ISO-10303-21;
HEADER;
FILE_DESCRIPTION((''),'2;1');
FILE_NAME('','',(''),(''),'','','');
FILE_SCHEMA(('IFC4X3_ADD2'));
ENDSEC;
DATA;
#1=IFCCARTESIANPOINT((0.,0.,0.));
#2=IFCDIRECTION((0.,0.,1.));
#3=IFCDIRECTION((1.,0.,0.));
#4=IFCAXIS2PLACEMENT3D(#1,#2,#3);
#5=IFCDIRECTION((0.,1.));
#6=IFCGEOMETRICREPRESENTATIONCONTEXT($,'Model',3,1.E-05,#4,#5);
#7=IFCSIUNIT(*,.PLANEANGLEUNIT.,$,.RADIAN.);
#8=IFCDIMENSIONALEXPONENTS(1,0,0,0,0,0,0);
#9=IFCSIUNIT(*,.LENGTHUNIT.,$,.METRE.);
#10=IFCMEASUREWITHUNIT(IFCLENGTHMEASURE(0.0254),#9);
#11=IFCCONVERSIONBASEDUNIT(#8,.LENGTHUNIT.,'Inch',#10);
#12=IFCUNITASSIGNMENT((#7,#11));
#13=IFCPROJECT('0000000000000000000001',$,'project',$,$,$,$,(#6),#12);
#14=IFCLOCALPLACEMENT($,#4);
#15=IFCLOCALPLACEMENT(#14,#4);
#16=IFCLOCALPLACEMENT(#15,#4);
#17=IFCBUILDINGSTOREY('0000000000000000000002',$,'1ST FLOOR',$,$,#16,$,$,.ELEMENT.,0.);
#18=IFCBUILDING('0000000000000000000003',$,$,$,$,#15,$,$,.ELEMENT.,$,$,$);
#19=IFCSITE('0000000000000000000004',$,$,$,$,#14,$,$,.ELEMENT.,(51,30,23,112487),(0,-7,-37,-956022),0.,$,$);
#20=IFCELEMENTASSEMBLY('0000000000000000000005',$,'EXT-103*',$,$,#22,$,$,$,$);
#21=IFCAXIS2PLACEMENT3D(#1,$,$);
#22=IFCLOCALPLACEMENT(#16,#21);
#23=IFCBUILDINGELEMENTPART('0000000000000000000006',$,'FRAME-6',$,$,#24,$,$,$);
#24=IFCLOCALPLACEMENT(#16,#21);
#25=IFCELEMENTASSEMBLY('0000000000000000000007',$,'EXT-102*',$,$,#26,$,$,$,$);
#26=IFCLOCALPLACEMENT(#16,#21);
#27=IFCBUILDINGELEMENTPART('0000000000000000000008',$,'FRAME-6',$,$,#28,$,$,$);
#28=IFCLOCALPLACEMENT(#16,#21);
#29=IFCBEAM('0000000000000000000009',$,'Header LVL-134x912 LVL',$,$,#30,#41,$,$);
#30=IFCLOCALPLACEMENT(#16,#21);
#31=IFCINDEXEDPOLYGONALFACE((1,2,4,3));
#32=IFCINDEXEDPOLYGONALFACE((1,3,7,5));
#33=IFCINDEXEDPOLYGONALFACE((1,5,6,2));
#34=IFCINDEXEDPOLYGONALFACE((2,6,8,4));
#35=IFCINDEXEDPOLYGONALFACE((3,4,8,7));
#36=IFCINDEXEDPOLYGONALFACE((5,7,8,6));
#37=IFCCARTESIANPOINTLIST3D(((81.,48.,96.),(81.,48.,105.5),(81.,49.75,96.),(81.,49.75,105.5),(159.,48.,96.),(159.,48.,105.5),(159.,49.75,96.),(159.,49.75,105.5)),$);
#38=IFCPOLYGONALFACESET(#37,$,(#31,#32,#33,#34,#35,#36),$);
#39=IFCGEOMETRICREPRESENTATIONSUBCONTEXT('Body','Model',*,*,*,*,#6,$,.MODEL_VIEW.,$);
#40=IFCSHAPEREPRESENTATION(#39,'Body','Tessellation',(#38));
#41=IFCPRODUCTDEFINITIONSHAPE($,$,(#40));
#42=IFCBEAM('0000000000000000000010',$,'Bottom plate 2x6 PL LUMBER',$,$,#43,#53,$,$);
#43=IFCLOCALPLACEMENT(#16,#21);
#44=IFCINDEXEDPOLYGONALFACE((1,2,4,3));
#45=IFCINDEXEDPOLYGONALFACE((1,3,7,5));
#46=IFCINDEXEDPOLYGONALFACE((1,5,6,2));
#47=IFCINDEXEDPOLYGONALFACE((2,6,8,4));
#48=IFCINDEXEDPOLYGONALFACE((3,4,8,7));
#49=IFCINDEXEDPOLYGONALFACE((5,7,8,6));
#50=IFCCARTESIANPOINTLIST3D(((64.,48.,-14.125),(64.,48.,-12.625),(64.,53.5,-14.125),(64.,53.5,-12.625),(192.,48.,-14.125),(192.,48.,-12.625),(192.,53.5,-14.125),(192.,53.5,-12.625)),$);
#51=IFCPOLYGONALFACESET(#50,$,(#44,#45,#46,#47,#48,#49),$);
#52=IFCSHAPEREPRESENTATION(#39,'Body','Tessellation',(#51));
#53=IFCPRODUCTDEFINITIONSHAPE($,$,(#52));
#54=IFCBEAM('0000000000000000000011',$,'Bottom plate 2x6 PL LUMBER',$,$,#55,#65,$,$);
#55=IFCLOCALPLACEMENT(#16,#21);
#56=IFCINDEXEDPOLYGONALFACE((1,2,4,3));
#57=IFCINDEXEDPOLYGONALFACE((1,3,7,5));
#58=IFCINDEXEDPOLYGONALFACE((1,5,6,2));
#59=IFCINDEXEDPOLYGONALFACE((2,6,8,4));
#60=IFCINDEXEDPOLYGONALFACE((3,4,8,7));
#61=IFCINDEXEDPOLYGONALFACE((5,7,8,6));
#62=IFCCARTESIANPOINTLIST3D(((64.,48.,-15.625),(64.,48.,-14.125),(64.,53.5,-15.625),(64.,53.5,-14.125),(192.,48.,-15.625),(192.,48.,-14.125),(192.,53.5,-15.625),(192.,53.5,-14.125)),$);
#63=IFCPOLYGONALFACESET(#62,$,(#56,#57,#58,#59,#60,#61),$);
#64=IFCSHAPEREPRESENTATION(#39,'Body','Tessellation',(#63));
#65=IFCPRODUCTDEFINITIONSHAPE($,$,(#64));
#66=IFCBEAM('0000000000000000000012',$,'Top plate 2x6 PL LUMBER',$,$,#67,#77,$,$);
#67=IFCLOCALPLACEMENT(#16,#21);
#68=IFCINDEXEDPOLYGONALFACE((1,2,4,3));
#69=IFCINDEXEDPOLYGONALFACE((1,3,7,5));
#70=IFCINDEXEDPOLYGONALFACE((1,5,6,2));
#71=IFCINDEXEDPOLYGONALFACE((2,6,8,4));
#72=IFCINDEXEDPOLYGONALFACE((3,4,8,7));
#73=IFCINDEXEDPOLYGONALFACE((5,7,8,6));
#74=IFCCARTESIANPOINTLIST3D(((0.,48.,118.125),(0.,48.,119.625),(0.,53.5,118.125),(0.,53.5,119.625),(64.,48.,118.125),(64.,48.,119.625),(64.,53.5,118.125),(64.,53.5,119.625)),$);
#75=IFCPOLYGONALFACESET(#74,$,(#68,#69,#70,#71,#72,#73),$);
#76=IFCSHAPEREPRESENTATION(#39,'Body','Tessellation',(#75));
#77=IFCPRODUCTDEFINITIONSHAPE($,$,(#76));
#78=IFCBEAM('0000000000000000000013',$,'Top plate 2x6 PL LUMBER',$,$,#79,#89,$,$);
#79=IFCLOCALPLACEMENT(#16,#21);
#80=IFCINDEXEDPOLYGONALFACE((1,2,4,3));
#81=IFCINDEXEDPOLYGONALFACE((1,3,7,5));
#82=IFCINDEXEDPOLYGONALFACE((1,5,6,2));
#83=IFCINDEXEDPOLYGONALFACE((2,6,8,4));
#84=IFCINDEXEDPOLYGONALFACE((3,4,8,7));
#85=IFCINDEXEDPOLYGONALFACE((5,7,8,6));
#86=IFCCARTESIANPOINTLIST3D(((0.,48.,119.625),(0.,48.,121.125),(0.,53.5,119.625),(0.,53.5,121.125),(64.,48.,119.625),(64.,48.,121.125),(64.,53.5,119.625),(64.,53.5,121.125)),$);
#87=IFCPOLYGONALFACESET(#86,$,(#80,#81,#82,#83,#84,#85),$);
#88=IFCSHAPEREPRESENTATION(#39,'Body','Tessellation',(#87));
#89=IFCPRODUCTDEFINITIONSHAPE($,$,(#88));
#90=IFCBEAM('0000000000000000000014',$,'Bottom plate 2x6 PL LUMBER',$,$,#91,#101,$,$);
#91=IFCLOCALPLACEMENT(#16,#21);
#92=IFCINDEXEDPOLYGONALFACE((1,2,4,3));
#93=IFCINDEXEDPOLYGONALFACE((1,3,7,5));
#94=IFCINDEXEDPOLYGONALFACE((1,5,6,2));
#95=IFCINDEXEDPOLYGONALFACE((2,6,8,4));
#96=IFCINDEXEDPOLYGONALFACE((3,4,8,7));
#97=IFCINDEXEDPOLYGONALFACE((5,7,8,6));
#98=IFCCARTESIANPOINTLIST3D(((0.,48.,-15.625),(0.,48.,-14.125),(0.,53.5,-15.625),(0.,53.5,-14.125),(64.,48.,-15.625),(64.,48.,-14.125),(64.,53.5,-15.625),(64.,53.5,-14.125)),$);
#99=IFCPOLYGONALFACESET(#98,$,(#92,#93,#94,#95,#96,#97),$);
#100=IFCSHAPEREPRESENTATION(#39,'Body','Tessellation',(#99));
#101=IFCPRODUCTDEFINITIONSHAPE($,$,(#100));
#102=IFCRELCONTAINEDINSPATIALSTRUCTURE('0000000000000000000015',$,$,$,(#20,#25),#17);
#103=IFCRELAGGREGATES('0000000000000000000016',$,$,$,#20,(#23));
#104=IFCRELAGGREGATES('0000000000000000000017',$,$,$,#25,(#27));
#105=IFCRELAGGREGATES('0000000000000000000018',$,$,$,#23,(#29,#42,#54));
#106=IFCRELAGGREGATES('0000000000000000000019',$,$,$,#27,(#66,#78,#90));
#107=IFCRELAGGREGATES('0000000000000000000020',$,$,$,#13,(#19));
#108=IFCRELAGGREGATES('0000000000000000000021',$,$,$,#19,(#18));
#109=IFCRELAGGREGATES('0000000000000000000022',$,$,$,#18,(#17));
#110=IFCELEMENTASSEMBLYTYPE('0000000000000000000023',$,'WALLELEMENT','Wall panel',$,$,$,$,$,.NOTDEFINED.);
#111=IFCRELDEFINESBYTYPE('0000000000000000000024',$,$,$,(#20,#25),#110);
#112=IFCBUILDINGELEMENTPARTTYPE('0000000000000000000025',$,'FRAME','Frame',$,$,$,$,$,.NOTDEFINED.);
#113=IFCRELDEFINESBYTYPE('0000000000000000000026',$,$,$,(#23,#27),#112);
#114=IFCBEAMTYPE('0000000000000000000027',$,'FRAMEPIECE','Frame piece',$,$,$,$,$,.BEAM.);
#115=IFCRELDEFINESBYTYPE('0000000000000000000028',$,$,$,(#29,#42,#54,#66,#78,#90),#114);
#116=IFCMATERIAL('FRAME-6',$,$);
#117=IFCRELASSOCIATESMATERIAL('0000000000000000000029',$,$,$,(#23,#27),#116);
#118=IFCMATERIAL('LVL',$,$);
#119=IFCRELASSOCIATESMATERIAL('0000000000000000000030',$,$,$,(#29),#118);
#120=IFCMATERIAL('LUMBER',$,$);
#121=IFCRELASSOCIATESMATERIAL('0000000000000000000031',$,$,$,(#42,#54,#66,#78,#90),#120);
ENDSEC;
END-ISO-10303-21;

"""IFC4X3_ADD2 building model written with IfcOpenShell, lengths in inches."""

from ifc_helpers import new_model, entity, si_unit, converted_unit, direction, frame, origin_with_axes, origin_2d_with_axis, place, context, subcontext, project, spatial, rectangle, extrude, material, type_object, element, aggregate, save


model = new_model("IFC4X3_ADD2")

# Units and contexts
model_context = context("Model", 3, precision=1e-05, world=origin_with_axes(), true_north=direction((0.0, 1.0)))
body_context = subcontext(model_context, "Body", "Model", "MODEL_VIEW")
ifc_project = project(units=[si_unit("PLANEANGLEUNIT", "RADIAN"), converted_unit("LENGTHUNIT", "Inch", entity("IfcLengthMeasure", 0.0254), si_unit("LENGTHUNIT", "METRE"), dimensions=[1, 0, 0, 0, 0, 0, 0])], contexts=[model_context])

# Site, building, storey
site_placement = place(None, origin_with_axes())
site = spatial("IfcSite", under=ifc_project, at=site_placement, CompositionType="ELEMENT", RefLatitude=(51, 30, 23, 112487), RefLongitude=(0, -7, -37, -956022), RefElevation=0.0)
building_placement = place(site_placement, origin_with_axes())
building = spatial("IfcBuilding", under=site, at=building_placement, CompositionType="ELEMENT")
storey_placement = place(building_placement, origin_with_axes())
storey = spatial("IfcBuildingStorey", under=building, at=storey_placement, Name="1ST FLOOR", CompositionType="ELEMENT", Elevation=0.0)

# Element assemblies, building element parts
element_assembly_type = type_object("IfcElementAssemblyType", Name="WALLELEMENT", Description="Wall panel", PredefinedType="NOTDEFINED")
assembly_1_placement = place(storey_placement, origin_with_axes())
assembly_1 = element("IfcElementAssembly", 1, at=assembly_1_placement, inside=storey, type_object=element_assembly_type, Name="EXT-103*")
ifc_material_1 = material(Name="FRAME-6")
building_element_part_type = type_object("IfcBuildingElementPartType", Name="FRAME", Description="Frame", PredefinedType="NOTDEFINED")
building_element_part_1_placement = place(storey_placement, origin_with_axes())
building_element_part_1 = element("IfcBuildingElementPart", 2, at=building_element_part_1_placement, type_object=building_element_part_type, material=ifc_material_1, Name="FRAME-6")
aggregate(assembly_1, [building_element_part_1])
ifc_material_2 = material(Name="LUMBER")
assembly_2_placement = place(storey_placement, origin_with_axes())
assembly_2 = element("IfcElementAssembly", 3, at=assembly_2_placement, inside=storey, type_object=element_assembly_type, Name="EXT-102*")
building_element_part_2_placement = place(storey_placement, origin_with_axes())
building_element_part_2 = element("IfcBuildingElementPart", 4, at=building_element_part_2_placement, type_object=building_element_part_type, material=ifc_material_1, Name="FRAME-6")
aggregate(assembly_2, [building_element_part_2])

# Beams
ifc_material_3 = material(Name="LVL")
beam_type = type_object("IfcBeamType", Name="FRAMEPIECE", Description="Frame piece", PredefinedType="BEAM")
beam_1_placement = place(storey_placement, frame((81.0, 48.875, 100.75), z_axis=(1.0, 0.0, 0.0), x_axis=(0.0, 1.0, 0.0)))
beam_1 = element("IfcBeam", 5, at=beam_1_placement, type_object=beam_type, material=ifc_material_3, Name="Header LVL-134x912 LVL", context=body_context, shape_type="SweptSolid", body=[
    extrude(rectangle(XDim=1.75, YDim=9.5, at=origin_2d_with_axis()), origin_with_axes(), (0.0, 0.0, 1.0), 78.0),
])
beam_2_placement = place(storey_placement, frame((64.0, 50.75, -13.375), z_axis=(1.0, 0.0, 0.0), x_axis=(0.0, 0.0, 1.0)))
beam_2 = element("IfcBeam", 6, at=beam_2_placement, type_object=beam_type, material=ifc_material_2, Name="Bottom plate 2x6 PL LUMBER", context=body_context, shape_type="SweptSolid", body=[
    extrude(rectangle(XDim=1.5, YDim=5.5, at=origin_2d_with_axis()), origin_with_axes(), (0.0, 0.0, 1.0), 128.0),
])
beam_3_placement = place(storey_placement, frame((64.0, 50.75, -14.875), z_axis=(1.0, 0.0, 0.0), x_axis=(0.0, 0.0, 1.0)))
beam_3 = element("IfcBeam", 7, at=beam_3_placement, type_object=beam_type, material=ifc_material_2, Name="Bottom plate 2x6 PL LUMBER", context=body_context, shape_type="SweptSolid", body=[
    extrude(rectangle(XDim=1.5, YDim=5.5, at=origin_2d_with_axis()), origin_with_axes(), (0.0, 0.0, 1.0), 128.0),
])
aggregate(building_element_part_1, [beam_1, beam_2, beam_3])
beam_4_placement = place(storey_placement, frame((64.0, 50.75, 118.875), z_axis=(-1.0, 0.0, 0.0), x_axis=(0.0, 0.0, -1.0)))
beam_4 = element("IfcBeam", 8, at=beam_4_placement, type_object=beam_type, material=ifc_material_2, Name="Top plate 2x6 PL LUMBER", context=body_context, shape_type="SweptSolid", body=[
    extrude(rectangle(XDim=1.5, YDim=5.5, at=origin_2d_with_axis()), origin_with_axes(), (0.0, 0.0, 1.0), 64.0),
])
beam_5_placement = place(storey_placement, frame((64.0, 50.75, 120.375), z_axis=(-1.0, 0.0, 0.0), x_axis=(0.0, 0.0, -1.0)))
beam_5 = element("IfcBeam", 9, at=beam_5_placement, type_object=beam_type, material=ifc_material_2, Name="Top plate 2x6 PL LUMBER", context=body_context, shape_type="SweptSolid", body=[
    extrude(rectangle(XDim=1.5, YDim=5.5, at=origin_2d_with_axis()), origin_with_axes(), (0.0, 0.0, 1.0), 64.0),
])
beam_6_placement = place(storey_placement, frame((0.0, 50.75, -14.875), z_axis=(1.0, 0.0, 0.0), x_axis=(0.0, 0.0, 1.0)))
beam_6 = element("IfcBeam", 10, at=beam_6_placement, type_object=beam_type, material=ifc_material_2, Name="Bottom plate 2x6 PL LUMBER", context=body_context, shape_type="SweptSolid", body=[
    extrude(rectangle(XDim=1.5, YDim=5.5, at=origin_2d_with_axis()), origin_with_axes(), (0.0, 0.0, 1.0), 64.0),
])
aggregate(building_element_part_2, [beam_4, beam_5, beam_6])

save(model, "model.ifc")
